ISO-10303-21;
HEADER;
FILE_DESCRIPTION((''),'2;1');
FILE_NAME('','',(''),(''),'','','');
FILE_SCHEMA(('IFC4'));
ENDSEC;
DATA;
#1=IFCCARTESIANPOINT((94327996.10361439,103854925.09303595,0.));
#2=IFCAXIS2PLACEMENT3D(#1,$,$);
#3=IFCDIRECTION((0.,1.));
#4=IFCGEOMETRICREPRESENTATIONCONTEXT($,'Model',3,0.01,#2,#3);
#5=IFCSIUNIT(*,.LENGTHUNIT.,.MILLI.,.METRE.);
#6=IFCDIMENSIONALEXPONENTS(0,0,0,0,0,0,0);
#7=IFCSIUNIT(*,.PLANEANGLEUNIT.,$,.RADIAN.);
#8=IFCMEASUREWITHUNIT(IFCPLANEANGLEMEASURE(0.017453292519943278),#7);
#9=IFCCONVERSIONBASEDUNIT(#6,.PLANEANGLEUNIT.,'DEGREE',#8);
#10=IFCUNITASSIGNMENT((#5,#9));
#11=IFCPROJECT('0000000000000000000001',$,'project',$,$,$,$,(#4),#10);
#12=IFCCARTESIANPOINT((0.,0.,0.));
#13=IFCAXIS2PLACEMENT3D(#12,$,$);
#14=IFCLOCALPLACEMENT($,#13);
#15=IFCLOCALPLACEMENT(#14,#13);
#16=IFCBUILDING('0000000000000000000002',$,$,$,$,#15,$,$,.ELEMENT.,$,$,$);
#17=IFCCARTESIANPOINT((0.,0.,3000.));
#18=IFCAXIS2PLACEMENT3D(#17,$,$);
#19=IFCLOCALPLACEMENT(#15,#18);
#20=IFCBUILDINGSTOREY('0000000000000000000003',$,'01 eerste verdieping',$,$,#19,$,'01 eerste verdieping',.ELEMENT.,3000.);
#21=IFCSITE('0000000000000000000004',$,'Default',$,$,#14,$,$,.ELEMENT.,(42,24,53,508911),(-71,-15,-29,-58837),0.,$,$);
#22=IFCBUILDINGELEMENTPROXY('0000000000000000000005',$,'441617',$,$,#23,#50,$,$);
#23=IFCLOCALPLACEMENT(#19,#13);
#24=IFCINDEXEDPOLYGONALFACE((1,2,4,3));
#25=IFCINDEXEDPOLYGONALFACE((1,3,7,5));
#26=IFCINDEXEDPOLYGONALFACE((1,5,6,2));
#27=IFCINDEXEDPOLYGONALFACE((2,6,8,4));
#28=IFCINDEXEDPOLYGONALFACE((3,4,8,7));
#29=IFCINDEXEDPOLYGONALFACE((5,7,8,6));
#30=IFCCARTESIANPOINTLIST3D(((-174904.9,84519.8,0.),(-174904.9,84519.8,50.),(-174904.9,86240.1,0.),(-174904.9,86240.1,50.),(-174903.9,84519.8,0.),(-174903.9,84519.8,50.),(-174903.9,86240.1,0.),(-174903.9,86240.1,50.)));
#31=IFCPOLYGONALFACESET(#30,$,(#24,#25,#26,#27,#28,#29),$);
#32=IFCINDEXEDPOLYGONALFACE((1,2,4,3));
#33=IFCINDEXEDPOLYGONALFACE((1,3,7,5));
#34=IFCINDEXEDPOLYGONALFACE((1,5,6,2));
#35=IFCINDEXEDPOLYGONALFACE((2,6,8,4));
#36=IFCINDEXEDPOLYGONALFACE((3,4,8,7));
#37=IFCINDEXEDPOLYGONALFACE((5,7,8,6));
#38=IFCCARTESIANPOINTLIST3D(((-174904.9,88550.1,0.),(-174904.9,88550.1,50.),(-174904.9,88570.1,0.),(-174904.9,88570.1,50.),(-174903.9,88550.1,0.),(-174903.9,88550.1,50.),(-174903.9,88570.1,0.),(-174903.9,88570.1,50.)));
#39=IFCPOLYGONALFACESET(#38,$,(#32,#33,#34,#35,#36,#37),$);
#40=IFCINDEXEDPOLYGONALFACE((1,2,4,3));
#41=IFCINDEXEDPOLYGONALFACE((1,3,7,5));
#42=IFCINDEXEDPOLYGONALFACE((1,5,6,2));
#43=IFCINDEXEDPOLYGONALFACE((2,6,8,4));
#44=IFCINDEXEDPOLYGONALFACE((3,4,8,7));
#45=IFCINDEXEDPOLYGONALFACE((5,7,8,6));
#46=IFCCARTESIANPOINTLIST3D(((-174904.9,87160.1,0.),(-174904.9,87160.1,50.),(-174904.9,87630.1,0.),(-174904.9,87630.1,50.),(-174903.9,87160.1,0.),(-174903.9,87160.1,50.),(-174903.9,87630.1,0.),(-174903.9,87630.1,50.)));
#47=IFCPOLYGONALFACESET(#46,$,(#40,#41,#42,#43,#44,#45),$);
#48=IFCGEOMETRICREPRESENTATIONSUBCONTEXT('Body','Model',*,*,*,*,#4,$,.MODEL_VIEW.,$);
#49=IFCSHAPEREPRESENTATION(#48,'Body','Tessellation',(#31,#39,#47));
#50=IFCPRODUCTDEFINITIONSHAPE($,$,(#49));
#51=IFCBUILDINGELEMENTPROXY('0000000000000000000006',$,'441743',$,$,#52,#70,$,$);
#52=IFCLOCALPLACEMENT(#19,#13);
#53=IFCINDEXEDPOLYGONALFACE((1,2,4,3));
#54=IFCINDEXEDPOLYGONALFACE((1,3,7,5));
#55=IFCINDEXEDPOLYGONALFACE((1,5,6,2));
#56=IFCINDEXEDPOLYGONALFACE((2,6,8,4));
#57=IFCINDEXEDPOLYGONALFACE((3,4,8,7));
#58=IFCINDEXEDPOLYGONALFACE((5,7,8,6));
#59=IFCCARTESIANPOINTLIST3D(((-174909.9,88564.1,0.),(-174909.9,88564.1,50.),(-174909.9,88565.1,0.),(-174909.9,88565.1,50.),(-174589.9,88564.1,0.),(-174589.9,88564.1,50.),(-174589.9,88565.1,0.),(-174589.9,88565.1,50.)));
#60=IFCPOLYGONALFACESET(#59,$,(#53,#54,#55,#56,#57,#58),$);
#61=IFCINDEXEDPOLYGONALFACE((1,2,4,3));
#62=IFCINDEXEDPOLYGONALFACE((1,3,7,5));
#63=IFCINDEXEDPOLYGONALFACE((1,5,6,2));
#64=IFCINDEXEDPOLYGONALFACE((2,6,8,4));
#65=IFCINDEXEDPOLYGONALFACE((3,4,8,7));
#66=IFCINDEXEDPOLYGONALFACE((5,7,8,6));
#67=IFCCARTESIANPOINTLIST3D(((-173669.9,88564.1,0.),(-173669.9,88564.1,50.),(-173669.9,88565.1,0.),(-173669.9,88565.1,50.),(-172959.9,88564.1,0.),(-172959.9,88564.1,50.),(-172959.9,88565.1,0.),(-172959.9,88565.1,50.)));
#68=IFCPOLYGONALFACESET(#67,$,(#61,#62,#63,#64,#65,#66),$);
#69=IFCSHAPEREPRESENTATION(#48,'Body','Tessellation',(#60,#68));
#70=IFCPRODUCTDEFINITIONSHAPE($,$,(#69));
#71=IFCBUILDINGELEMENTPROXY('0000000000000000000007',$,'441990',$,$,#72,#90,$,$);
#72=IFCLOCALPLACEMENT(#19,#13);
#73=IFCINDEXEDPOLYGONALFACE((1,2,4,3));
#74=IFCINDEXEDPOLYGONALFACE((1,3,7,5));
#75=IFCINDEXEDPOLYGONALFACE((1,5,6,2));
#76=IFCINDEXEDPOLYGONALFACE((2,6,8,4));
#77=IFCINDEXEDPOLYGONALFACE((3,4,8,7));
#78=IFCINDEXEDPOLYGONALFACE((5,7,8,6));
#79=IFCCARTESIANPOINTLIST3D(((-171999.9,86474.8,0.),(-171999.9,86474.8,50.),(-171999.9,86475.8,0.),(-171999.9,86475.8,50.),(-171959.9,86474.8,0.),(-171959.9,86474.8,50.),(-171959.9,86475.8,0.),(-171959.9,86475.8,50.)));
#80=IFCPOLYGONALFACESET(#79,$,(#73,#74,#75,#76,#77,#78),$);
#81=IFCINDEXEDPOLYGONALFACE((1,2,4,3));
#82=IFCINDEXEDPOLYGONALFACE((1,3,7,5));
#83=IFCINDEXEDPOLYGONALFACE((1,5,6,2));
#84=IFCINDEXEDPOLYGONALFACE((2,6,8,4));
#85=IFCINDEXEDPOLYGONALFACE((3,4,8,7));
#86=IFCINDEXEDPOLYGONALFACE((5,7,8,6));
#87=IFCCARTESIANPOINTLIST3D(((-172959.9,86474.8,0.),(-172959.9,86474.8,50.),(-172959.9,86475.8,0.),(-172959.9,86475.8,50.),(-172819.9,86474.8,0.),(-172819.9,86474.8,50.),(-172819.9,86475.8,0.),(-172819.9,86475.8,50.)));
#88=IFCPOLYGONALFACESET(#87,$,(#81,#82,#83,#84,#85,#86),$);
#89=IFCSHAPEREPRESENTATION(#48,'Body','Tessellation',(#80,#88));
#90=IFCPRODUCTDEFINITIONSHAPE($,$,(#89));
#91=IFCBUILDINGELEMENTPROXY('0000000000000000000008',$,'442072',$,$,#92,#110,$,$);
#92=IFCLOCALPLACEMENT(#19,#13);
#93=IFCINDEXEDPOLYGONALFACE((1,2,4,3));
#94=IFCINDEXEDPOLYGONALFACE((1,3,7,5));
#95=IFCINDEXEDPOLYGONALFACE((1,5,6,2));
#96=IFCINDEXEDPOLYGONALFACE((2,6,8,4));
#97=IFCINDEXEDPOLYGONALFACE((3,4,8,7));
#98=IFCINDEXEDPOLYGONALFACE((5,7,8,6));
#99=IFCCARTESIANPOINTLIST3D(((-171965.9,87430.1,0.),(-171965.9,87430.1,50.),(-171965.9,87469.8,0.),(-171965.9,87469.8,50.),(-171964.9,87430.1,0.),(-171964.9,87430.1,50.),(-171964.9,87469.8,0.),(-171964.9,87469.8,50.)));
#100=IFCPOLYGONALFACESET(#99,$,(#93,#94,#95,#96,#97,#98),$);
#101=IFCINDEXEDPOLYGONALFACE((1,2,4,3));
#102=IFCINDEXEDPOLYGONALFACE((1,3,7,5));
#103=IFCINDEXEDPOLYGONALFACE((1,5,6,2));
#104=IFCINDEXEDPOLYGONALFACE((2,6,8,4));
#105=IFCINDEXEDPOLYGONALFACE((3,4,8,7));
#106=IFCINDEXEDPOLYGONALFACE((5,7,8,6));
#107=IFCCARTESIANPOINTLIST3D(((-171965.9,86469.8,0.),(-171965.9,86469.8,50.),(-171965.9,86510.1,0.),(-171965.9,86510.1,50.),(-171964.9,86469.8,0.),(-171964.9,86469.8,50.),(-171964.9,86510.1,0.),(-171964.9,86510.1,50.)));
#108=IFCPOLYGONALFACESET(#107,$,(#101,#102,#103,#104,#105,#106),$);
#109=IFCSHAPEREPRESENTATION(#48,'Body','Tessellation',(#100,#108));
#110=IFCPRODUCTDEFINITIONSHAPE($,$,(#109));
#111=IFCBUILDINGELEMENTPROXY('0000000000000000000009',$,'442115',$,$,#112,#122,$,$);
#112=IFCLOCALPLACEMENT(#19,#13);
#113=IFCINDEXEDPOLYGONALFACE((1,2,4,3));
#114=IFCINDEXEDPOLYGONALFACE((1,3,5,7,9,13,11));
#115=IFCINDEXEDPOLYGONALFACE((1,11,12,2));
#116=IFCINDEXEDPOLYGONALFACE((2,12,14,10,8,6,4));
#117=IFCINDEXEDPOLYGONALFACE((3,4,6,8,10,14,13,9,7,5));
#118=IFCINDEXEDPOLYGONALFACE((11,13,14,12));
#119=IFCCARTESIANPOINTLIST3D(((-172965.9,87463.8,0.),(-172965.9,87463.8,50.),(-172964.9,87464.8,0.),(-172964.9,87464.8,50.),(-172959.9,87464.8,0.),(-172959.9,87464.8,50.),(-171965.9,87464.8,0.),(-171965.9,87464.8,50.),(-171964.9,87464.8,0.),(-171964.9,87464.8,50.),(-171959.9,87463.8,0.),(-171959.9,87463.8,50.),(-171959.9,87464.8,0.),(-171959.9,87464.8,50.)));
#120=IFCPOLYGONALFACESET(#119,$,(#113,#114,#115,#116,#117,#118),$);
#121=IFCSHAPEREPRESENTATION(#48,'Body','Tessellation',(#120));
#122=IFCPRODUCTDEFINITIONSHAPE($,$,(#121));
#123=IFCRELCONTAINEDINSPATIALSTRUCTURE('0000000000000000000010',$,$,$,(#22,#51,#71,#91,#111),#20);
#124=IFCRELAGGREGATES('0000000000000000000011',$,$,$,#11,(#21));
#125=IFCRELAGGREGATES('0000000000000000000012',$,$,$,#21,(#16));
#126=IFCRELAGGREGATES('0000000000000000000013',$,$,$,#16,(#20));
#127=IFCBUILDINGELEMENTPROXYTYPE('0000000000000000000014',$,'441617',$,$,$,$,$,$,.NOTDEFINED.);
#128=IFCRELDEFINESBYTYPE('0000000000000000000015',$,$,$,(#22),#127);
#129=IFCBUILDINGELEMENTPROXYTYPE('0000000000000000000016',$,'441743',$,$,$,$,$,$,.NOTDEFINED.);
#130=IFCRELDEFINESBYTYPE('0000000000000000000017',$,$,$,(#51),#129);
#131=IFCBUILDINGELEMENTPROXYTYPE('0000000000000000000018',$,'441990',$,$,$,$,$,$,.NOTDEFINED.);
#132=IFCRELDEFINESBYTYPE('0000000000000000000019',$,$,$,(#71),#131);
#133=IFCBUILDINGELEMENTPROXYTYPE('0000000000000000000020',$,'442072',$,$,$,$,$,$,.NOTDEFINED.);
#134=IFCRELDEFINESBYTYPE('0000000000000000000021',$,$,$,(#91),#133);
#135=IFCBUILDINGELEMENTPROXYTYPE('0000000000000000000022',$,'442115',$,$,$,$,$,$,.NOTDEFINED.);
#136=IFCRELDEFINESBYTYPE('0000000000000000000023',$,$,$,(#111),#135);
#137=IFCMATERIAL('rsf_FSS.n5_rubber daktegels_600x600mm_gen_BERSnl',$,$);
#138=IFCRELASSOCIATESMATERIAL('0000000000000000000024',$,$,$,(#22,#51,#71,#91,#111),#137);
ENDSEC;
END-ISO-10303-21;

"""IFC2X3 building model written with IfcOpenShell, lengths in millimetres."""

from ifc_helpers import new_model, entity, si_unit, converted_unit, direction, frame, frame_2d, origin, place, context, subcontext, project, spatial, polyline, rectangle, outline, extrude, material, type_object, element, save


model = new_model("IFC2X3")

# Units and contexts
model_context = context("Model", 3, precision=0.01, world=frame((94327996.10361439, 103854925.09303595, 0.0)), true_north=direction((0.0, 1.0)))
body_context = subcontext(model_context, "Body", "Model", "MODEL_VIEW")
ifc_project = project(units=[si_unit("LENGTHUNIT", "METRE", prefix="MILLI"), converted_unit("PLANEANGLEUNIT", "DEGREE", entity("IfcPlaneAngleMeasure", 0.017453292519943278), si_unit("PLANEANGLEUNIT", "RADIAN"), dimensions=[0, 0, 0, 0, 0, 0, 0])], contexts=[model_context])

# Site, building, storey
site_placement = place(None, origin())
site = spatial("IfcSite", under=ifc_project, at=site_placement, Name="Default", CompositionType="ELEMENT", RefLatitude=(42, 24, 53, 508911), RefLongitude=(-71, -15, -29, -58837), RefElevation=0.0)
building_placement = place(site_placement, origin())
building = spatial("IfcBuilding", under=site, at=building_placement, CompositionType="ELEMENT")
storey_placement = place(building_placement, frame((0.0, 0.0, 3000.0)))
storey = spatial("IfcBuildingStorey", under=building, at=storey_placement, Name="01 eerste verdieping", LongName="01 eerste verdieping", CompositionType="ELEMENT", Elevation=3000.0)

# Building element proxies
ifc_material = material(Name="rsf_FSS.n5_rubber daktegels_600x600mm_gen_BERSnl")
building_element_proxy_type_1 = type_object("IfcBuildingElementProxyType", Name="441617", PredefinedType="NOTDEFINED")
proxy_1_placement = place(storey_placement, origin())
element("IfcBuildingElementProxy", 1, at=proxy_1_placement, inside=storey, type_object=building_element_proxy_type_1, material=ifc_material, Name="441617", context=body_context, shape_type="SweptSolid", body=[
    extrude(rectangle(XDim=1720.4, YDim=1.0, at=frame_2d((0.0, 0.0), x_axis=(1.0, 0.0))), frame((-174904.4, 85380.0, 0.0), z_axis=(0.0, 0.0, 1.0), x_axis=(0.0, 1.0, 0.0)), (0.0, 0.0, 1.0), 50.0),
    extrude(rectangle(XDim=20.0, YDim=1.0, at=frame_2d((0.0, 0.0), x_axis=(1.0, 0.0))), frame((-174904.4, 88560.1, 0.0), z_axis=(0.0, 0.0, 1.0), x_axis=(0.0, 1.0, 0.0)), (0.0, 0.0, 1.0), 50.0),
    extrude(rectangle(XDim=470.0, YDim=1.0, at=frame_2d((0.0, 0.0), x_axis=(1.0, 0.0))), frame((-174904.4, 87395.1, 0.0), z_axis=(0.0, 0.0, 1.0), x_axis=(0.0, 1.0, 0.0)), (0.0, 0.0, 1.0), 50.0),
])
building_element_proxy_type_2 = type_object("IfcBuildingElementProxyType", Name="441743", PredefinedType="NOTDEFINED")
proxy_2_placement = place(storey_placement, origin())
element("IfcBuildingElementProxy", 2, at=proxy_2_placement, inside=storey, type_object=building_element_proxy_type_2, material=ifc_material, Name="441743", context=body_context, shape_type="SweptSolid", body=[
    extrude(rectangle(XDim=320.0, YDim=1.0, at=frame_2d((0.0, 0.0), x_axis=(1.0, 0.0))), frame((-174749.9, 88564.6, 0.0)), (0.0, 0.0, 1.0), 50.0),
    extrude(rectangle(XDim=710.0, YDim=1.0, at=frame_2d((0.0, 0.0), x_axis=(1.0, 0.0))), frame((-173314.9, 88564.6, 0.0)), (0.0, 0.0, 1.0), 50.0),
])
building_element_proxy_type_3 = type_object("IfcBuildingElementProxyType", Name="441990", PredefinedType="NOTDEFINED")
proxy_3_placement = place(storey_placement, origin())
element("IfcBuildingElementProxy", 3, at=proxy_3_placement, inside=storey, type_object=building_element_proxy_type_3, material=ifc_material, Name="441990", context=body_context, shape_type="SweptSolid", body=[
    extrude(rectangle(XDim=40.0, YDim=1.0, at=frame_2d((0.0, 0.0), x_axis=(1.0, 0.0))), frame((-171979.9, 86475.3, 0.0)), (0.0, 0.0, 1.0), 50.0),
    extrude(rectangle(XDim=140.0, YDim=1.0, at=frame_2d((0.0, 0.0), x_axis=(1.0, 0.0))), frame((-172889.9, 86475.3, 0.0)), (0.0, 0.0, 1.0), 50.0),
])
building_element_proxy_type_4 = type_object("IfcBuildingElementProxyType", Name="442072", PredefinedType="NOTDEFINED")
proxy_4_placement = place(storey_placement, origin())
element("IfcBuildingElementProxy", 4, at=proxy_4_placement, inside=storey, type_object=building_element_proxy_type_4, material=ifc_material, Name="442072", context=body_context, shape_type="SweptSolid", body=[
    extrude(rectangle(XDim=39.6, YDim=1.0, at=frame_2d((0.0, 0.0), x_axis=(1.0, 0.0))), frame((-171965.4, 87450.0, 0.0), z_axis=(0.0, 0.0, 1.0), x_axis=(0.0, 1.0, 0.0)), (0.0, 0.0, 1.0), 50.0),
    extrude(rectangle(XDim=40.4, YDim=1.0, at=frame_2d((0.0, 0.0), x_axis=(1.0, 0.0))), frame((-171965.4, 86490.0, 0.0), z_axis=(0.0, 0.0, 1.0), x_axis=(0.0, 1.0, 0.0)), (0.0, 0.0, 1.0), 50.0),
])
building_element_proxy_type_5 = type_object("IfcBuildingElementProxyType", Name="442115", PredefinedType="NOTDEFINED")
proxy_5_placement = place(storey_placement, origin())
element("IfcBuildingElementProxy", 5, at=proxy_5_placement, inside=storey, type_object=building_element_proxy_type_5, material=ifc_material, Name="442115", context=body_context, shape_type="SweptSolid", body=[
    extrude(outline(polyline([(-431.7, -0.3), (-426.7, -0.3), (-425.7, -0.3), (568.3, -0.3), (573.3, -0.3), (574.3, 0.7), (-431.7, 0.7), (-431.7, -0.3)])), frame((-172391.6, 87464.5, 0.0), z_axis=(0.0, 0.0, 1.0), x_axis=(-1.0, 0.0, 0.0)), (0.0, 0.0, 1.0), 50.0),
])

save(model, "model.ifc")
